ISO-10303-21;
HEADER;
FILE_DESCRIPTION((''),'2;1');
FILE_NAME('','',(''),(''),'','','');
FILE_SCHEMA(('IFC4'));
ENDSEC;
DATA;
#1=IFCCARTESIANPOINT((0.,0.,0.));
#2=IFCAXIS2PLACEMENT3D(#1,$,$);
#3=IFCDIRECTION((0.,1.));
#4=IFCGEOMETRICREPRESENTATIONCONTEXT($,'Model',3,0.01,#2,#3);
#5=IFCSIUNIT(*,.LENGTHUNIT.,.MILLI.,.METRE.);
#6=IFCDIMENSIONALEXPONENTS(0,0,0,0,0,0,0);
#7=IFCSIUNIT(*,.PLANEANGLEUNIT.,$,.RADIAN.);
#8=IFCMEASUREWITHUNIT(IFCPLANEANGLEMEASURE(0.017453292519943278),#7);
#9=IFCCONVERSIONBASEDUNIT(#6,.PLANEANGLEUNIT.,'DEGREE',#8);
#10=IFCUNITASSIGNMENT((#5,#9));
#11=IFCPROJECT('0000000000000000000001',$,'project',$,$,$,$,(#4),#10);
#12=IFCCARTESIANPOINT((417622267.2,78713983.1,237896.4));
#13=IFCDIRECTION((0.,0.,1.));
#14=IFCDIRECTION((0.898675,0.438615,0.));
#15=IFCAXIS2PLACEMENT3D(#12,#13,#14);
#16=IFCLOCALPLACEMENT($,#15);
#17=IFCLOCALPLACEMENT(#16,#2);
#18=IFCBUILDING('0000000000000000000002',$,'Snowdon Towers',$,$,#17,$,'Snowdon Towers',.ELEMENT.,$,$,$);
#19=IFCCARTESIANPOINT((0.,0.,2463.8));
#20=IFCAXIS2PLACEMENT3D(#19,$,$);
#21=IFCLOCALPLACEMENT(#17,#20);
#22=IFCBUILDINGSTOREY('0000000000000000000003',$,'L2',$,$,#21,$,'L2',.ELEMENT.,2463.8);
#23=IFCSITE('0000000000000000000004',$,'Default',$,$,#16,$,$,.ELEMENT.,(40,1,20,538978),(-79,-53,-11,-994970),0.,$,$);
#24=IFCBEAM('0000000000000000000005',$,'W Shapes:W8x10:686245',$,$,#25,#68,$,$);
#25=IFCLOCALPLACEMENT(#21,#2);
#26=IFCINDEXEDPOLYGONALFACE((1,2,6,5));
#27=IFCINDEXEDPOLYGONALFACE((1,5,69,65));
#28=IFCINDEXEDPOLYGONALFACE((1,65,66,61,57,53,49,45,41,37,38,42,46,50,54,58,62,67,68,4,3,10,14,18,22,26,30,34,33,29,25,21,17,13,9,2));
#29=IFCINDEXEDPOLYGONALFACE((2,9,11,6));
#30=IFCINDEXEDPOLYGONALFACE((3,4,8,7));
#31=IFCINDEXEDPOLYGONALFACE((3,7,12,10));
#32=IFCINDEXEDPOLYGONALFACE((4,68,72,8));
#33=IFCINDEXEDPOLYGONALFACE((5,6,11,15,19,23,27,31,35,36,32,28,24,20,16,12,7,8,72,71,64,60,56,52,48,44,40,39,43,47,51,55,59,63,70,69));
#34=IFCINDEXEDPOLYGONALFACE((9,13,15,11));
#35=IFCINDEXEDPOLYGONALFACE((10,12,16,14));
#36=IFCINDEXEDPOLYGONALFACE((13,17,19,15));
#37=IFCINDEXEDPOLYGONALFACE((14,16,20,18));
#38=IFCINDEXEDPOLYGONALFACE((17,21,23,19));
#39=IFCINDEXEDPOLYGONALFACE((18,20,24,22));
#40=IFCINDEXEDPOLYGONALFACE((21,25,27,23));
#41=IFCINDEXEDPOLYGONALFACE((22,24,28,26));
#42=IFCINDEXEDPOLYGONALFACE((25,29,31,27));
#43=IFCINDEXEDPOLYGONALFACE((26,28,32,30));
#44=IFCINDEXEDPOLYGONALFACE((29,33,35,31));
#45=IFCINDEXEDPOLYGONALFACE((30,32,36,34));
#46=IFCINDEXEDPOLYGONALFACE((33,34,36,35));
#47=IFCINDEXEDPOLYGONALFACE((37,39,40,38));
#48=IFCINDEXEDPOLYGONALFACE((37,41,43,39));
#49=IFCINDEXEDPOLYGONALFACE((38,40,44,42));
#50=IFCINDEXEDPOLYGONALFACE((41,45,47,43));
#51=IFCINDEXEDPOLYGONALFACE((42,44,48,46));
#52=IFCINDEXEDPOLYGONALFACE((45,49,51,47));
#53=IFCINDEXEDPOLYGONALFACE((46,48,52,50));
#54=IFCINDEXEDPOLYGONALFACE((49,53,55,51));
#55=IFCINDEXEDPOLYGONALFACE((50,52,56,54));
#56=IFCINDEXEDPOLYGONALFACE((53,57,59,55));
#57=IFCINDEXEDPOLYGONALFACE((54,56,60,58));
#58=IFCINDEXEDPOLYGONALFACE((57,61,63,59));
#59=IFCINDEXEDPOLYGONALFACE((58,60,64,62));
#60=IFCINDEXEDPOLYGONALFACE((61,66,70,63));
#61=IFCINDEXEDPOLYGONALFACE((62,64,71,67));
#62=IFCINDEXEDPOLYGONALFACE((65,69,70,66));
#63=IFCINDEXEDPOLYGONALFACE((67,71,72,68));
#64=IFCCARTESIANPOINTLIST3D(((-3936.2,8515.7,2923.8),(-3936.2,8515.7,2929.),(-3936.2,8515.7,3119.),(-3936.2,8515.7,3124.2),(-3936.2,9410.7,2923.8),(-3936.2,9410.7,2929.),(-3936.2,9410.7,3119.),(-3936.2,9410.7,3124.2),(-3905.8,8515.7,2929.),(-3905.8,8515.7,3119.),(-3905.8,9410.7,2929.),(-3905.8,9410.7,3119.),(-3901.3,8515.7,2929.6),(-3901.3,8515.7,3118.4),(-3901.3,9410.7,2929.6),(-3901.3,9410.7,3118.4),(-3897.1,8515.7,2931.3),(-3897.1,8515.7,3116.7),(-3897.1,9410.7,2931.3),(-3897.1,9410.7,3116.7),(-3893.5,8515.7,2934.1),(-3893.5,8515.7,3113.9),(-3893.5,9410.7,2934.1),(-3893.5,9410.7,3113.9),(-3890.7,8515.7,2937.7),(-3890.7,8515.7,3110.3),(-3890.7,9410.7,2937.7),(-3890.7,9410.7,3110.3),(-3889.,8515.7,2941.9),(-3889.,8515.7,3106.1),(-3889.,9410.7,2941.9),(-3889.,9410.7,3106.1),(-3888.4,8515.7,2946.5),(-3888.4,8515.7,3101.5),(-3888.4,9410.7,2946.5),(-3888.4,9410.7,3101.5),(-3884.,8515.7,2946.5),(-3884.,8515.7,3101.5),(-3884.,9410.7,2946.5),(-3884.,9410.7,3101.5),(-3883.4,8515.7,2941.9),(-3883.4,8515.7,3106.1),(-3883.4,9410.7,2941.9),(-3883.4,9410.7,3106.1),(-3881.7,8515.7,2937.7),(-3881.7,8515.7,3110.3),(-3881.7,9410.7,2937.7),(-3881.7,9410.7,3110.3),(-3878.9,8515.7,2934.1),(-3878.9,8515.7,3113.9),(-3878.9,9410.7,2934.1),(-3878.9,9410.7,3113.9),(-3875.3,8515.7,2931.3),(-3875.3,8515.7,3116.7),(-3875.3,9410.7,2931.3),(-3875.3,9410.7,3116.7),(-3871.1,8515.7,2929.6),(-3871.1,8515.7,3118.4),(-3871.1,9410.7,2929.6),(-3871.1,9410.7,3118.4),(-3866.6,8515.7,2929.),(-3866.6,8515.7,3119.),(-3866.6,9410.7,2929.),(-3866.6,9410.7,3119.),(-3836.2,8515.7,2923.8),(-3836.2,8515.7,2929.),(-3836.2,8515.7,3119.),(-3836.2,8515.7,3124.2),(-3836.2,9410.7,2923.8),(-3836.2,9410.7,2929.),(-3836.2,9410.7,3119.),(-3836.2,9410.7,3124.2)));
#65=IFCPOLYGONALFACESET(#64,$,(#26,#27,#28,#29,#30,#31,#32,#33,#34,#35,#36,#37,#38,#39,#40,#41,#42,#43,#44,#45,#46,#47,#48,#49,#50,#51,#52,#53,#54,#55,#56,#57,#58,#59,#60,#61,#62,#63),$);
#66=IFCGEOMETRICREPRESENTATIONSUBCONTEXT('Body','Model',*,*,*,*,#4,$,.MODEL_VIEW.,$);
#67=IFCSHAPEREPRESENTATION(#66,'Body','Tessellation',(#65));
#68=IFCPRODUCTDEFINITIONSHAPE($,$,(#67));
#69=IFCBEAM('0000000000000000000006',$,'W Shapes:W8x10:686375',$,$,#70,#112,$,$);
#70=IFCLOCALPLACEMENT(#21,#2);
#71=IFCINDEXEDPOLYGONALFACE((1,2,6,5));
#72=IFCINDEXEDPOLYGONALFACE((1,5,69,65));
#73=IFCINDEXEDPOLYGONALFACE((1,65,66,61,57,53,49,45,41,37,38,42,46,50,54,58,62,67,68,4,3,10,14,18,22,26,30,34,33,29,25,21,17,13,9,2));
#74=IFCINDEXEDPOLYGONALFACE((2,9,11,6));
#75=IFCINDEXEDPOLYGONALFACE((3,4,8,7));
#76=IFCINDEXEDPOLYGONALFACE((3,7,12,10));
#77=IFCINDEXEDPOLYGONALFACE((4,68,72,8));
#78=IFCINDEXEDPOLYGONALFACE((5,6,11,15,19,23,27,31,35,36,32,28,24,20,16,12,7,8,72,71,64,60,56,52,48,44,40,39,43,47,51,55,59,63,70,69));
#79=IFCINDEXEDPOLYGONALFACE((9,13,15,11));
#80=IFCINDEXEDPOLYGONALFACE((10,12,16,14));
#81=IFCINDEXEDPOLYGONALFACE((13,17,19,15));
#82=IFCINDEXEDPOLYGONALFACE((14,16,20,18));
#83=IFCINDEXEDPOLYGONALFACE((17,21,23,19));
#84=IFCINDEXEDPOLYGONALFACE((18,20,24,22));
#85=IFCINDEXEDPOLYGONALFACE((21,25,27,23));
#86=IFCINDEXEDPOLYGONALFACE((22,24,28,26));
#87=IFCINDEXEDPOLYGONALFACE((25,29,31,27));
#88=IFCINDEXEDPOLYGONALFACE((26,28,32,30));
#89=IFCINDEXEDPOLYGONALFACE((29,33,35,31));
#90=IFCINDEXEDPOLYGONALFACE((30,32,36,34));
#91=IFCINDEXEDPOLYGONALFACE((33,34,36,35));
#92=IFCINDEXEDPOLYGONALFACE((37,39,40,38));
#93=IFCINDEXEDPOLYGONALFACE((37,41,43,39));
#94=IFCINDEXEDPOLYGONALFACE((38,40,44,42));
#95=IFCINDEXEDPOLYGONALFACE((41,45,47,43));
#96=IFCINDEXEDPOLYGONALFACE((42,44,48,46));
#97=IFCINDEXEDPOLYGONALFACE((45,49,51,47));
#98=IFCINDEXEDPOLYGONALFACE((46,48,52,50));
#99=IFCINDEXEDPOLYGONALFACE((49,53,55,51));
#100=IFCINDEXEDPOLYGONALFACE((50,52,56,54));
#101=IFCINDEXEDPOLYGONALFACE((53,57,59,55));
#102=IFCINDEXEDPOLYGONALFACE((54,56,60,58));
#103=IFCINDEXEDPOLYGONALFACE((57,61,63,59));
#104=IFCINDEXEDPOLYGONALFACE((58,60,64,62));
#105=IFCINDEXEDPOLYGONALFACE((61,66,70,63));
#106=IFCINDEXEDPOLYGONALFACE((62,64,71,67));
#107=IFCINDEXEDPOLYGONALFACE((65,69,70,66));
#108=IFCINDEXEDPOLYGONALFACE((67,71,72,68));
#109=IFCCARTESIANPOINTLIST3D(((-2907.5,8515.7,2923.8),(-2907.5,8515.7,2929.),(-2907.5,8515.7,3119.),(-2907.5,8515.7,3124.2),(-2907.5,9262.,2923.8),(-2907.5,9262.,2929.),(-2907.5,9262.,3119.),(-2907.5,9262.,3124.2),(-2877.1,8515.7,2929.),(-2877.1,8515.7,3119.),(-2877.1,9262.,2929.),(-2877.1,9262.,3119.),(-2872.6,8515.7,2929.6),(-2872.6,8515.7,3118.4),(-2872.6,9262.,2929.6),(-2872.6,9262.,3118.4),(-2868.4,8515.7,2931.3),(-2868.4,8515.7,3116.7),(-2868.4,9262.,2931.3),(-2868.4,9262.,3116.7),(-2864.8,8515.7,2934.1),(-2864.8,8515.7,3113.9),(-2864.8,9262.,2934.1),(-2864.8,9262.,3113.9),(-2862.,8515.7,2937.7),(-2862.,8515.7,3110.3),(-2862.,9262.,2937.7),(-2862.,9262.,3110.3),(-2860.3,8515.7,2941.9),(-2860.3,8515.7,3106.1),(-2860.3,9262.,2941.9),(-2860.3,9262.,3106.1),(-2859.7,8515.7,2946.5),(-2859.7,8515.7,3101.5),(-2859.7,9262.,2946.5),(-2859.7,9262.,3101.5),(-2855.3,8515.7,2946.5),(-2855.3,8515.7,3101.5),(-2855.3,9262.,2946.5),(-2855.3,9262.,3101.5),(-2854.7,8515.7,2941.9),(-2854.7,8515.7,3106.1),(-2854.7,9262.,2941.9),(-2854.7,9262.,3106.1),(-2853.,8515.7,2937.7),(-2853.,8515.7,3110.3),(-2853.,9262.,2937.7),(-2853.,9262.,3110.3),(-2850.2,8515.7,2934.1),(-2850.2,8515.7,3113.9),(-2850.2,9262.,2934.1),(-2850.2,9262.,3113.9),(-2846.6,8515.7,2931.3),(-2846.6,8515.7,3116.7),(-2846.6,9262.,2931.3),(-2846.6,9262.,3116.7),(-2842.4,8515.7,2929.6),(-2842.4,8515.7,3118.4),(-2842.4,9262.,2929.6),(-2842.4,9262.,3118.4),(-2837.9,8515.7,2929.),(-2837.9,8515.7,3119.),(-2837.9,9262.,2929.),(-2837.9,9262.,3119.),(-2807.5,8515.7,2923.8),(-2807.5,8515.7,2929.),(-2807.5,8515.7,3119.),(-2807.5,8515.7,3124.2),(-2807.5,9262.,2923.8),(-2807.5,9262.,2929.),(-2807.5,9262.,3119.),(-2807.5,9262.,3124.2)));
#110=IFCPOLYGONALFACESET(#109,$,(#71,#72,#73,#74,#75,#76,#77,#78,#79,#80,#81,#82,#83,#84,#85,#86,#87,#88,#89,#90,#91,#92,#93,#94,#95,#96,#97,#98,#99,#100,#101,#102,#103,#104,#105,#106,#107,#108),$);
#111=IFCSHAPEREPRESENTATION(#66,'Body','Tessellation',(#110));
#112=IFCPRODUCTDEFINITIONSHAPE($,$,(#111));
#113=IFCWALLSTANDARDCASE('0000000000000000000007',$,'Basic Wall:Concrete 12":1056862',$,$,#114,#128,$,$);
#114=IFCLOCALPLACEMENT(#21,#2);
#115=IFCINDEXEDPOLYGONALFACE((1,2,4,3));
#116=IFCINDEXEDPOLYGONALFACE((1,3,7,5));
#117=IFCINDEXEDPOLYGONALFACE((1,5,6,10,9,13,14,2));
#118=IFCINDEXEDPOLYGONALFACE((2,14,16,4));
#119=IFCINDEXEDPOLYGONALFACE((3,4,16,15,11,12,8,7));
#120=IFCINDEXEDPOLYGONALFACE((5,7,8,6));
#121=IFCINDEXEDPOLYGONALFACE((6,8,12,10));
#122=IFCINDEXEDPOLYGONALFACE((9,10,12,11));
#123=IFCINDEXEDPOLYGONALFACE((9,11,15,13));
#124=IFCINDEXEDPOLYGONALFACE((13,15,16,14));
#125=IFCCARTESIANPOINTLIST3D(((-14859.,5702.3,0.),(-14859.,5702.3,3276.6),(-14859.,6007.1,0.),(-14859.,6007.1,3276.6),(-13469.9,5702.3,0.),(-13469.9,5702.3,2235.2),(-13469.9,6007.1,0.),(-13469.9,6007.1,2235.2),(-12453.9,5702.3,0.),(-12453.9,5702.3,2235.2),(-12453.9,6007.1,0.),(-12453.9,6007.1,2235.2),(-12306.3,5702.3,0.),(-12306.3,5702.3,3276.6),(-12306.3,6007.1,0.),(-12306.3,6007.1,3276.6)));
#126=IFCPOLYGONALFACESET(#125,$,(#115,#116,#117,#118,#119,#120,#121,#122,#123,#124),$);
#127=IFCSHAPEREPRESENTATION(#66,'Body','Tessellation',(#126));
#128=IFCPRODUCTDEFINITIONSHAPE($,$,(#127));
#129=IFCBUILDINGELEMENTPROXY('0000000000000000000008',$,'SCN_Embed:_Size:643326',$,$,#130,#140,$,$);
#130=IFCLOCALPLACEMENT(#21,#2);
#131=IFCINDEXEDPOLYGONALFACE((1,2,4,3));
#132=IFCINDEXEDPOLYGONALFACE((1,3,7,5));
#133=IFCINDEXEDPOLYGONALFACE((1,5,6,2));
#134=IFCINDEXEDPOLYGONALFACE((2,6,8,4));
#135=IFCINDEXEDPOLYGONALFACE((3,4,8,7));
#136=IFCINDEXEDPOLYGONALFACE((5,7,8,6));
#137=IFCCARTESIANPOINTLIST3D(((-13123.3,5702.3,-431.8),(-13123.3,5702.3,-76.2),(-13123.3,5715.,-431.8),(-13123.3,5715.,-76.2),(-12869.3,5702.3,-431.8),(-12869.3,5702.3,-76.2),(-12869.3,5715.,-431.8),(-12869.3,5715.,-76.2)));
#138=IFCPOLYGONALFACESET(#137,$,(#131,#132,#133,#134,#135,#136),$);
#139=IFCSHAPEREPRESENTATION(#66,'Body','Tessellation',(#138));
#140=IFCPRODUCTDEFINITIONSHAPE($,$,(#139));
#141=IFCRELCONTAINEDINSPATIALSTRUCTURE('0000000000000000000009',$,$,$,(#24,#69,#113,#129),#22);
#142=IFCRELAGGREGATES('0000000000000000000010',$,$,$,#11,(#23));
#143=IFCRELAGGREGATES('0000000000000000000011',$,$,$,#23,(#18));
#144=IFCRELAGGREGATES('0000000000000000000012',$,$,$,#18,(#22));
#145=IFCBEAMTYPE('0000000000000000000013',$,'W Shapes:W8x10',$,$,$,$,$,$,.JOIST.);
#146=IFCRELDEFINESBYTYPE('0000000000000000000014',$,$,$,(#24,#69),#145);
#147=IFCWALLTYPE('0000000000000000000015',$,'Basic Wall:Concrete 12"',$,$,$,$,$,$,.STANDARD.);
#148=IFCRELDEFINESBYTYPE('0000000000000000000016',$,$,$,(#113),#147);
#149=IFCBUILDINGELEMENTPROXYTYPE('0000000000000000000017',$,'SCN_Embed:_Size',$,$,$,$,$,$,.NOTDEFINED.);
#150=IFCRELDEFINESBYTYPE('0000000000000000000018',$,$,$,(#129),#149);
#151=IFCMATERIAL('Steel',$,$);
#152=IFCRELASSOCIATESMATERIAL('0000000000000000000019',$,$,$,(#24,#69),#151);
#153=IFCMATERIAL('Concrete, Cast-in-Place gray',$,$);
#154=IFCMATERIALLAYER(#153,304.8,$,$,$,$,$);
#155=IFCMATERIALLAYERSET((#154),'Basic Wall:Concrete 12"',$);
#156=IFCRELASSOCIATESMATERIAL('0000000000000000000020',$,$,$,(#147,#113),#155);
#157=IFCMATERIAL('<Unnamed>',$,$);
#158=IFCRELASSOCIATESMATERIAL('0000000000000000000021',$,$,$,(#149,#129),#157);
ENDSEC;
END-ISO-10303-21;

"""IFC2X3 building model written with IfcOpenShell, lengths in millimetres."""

from ifc_helpers import new_model, entity, si_unit, converted_unit, direction, frame, frame_2d, origin, place, context, subcontext, project, spatial, rectangle, i_section, extrude, source, transform, mapped, material, layer, layer_set, layer_usage, type_object, type_shapes, element, save


model = new_model("IFC2X3")

# Units and contexts
model_context = context("Model", 3, precision=0.01, world=origin(), true_north=direction((0.0, 1.0)))
body_context = subcontext(model_context, "Body", "Model", "MODEL_VIEW")
ifc_project = project(units=[si_unit("LENGTHUNIT", "METRE", prefix="MILLI"), converted_unit("PLANEANGLEUNIT", "DEGREE", entity("IfcPlaneAngleMeasure", 0.017453292519943278), si_unit("PLANEANGLEUNIT", "RADIAN"), dimensions=[0, 0, 0, 0, 0, 0, 0])], contexts=[model_context])

# Site, building, storey
site_placement = place(None, frame((417622267.2, 78713983.1, 237896.4), z_axis=(0.0, 0.0, 1.0), x_axis=(0.898675, 0.438615, 0.0)))
site = spatial("IfcSite", under=ifc_project, at=site_placement, Name="Default", CompositionType="ELEMENT", RefLatitude=(40, 1, 20, 538978), RefLongitude=(-79, -53, -11, -994970), RefElevation=0.0)
building_placement = place(site_placement, origin())
building = spatial("IfcBuilding", under=site, at=building_placement, Name="Snowdon Towers", LongName="Snowdon Towers", CompositionType="ELEMENT")
storey_placement = place(building_placement, frame((0.0, 0.0, 2463.8)))
storey = spatial("IfcBuildingStorey", under=building, at=storey_placement, Name="L2", LongName="L2", CompositionType="ELEMENT", Elevation=2463.8)

# Beams
ifc_material_1 = material(Name="Steel")
beam_type_1 = type_object("IfcBeamType", Name="W Shapes:W8x10", PredefinedType="JOIST")
beam_1_placement = place(storey_placement, frame((-3886.2, 8420.1, 3124.2), z_axis=(0.0, 0.0, 1.0), x_axis=(0.0, 1.0, 0.0)))
element("IfcBeam", 1, at=beam_1_placement, inside=storey, type_object=beam_type_1, material=ifc_material_1, Name="W Shapes:W8x10:686245", context=body_context, shape_type="SweptSolid", body=[
    extrude(i_section(OverallWidth=100.1, OverallDepth=200.4, WebThickness=4.3, FlangeThickness=5.2, FilletRadius=17.5, at=frame_2d((0.0, 0.0), x_axis=(0.0, 1.0))), frame((95.6, 0.0, -100.2), z_axis=(1.0, 0.0, 0.0), x_axis=(0.0, 0.0, -1.0)), (0.0, 0.0, 1.0), 895.0),
])
beam_2_placement = place(storey_placement, frame((-2857.5, 8420.1, 3124.2), z_axis=(0.0, 0.0, 1.0), x_axis=(0.0, 1.0, 0.0)))
element("IfcBeam", 2, at=beam_2_placement, inside=storey, type_object=beam_type_1, material=ifc_material_1, Name="W Shapes:W8x10:686375", context=body_context, shape_type="SweptSolid", body=[
    extrude(i_section(OverallWidth=100.1, OverallDepth=200.4, WebThickness=4.3, FlangeThickness=5.2, FilletRadius=17.5, at=frame_2d((0.0, 0.0), x_axis=(0.0, 1.0))), frame((95.6, 0.0, -100.2), z_axis=(1.0, 0.0, 0.0), x_axis=(0.0, 0.0, -1.0)), (0.0, 0.0, 1.0), 746.3),
])

# Shared definitions
ifc_material_2 = material(Name="Concrete, Cast-in-Place gray")

# Wall, opening
ifc_layer_1 = layer(ifc_material_2, 304.8)
ifc_layer_set_1 = layer_set([ifc_layer_1], Name="Basic Wall:Concrete 12\"")
ifc_layer_usage_1 = layer_usage(ifc_layer_set_1, "AXIS2", "POSITIVE", -152.4)
wall_type = type_object("IfcWallType", Name="Basic Wall:Concrete 12\"", PredefinedType="STANDARD", material=ifc_layer_set_1)
wall_placement = place(storey_placement, frame((-12306.3, 5854.7, 0.0), z_axis=(0.0, 0.0, 1.0), x_axis=(-1.0, 0.0, 0.0)))
wall = element("IfcWallStandardCase", 3, at=wall_placement, inside=storey, type_object=wall_type, material=ifc_layer_usage_1, Name="Basic Wall:Concrete 12\":1056862", context=body_context, shape_type="SweptSolid", body=[
    extrude(rectangle(XDim=2552.7, YDim=304.8, at=frame_2d((1276.3, 0.0), x_axis=(-1.0, 0.0))), origin(), (0.0, 0.0, 1.0), 3276.6),
])
opening_1_placement = place(wall_placement, origin())
element("IfcOpeningElement", 4, at=opening_1_placement, cuts=wall, ObjectType="Opening", context=body_context, shape_type="SweptSolid", body=[
    extrude(rectangle(XDim=2235.2, YDim=1016.0, at=frame_2d((0.0, 0.0), x_axis=(0.0, 1.0))), frame((655.6, 152.4, 1117.6), z_axis=(0.0, -1.0, 0.0), x_axis=(1.0, 0.0, 0.0)), (0.0, 0.0, 1.0), 304.8),
])

# Building element proxy
ifc_material_3 = material(Name="<Unnamed>")
building_element_proxy_type_1 = type_object("IfcBuildingElementProxyType", Name="SCN_Embed:_Size", PredefinedType="NOTDEFINED", material=ifc_material_3)
shared_shape_1 = source(origin(), body_context, "Body", "SweptSolid", [
    extrude(rectangle(XDim=254.0, YDim=355.6, at=frame_2d((0.0, 0.0), x_axis=(1.0, 0.0))), frame((0.0, 0.0, -12.7), z_axis=(0.0, 0.0, 1.0), x_axis=(-1.0, 0.0, 0.0)), (0.0, 0.0, 1.0), 12.7),
])
type_shapes(building_element_proxy_type_1, [shared_shape_1])
proxy_placement = place(storey_placement, frame((-12996.3, 5702.3, -254.0), z_axis=(0.0, -1.0, 0.0), x_axis=(1.0, 0.0, 0.0)))
element("IfcBuildingElementProxy", 5, at=proxy_placement, inside=storey, type_object=building_element_proxy_type_1, material=ifc_material_3, Name="SCN_Embed:_Size:643326", context=body_context, shape_type="MappedRepresentation", body=[
    mapped(shared_shape_1, transform((0.0, 0.0, 0.0), scale=1.0)),
])

save(model, "model.ifc")
